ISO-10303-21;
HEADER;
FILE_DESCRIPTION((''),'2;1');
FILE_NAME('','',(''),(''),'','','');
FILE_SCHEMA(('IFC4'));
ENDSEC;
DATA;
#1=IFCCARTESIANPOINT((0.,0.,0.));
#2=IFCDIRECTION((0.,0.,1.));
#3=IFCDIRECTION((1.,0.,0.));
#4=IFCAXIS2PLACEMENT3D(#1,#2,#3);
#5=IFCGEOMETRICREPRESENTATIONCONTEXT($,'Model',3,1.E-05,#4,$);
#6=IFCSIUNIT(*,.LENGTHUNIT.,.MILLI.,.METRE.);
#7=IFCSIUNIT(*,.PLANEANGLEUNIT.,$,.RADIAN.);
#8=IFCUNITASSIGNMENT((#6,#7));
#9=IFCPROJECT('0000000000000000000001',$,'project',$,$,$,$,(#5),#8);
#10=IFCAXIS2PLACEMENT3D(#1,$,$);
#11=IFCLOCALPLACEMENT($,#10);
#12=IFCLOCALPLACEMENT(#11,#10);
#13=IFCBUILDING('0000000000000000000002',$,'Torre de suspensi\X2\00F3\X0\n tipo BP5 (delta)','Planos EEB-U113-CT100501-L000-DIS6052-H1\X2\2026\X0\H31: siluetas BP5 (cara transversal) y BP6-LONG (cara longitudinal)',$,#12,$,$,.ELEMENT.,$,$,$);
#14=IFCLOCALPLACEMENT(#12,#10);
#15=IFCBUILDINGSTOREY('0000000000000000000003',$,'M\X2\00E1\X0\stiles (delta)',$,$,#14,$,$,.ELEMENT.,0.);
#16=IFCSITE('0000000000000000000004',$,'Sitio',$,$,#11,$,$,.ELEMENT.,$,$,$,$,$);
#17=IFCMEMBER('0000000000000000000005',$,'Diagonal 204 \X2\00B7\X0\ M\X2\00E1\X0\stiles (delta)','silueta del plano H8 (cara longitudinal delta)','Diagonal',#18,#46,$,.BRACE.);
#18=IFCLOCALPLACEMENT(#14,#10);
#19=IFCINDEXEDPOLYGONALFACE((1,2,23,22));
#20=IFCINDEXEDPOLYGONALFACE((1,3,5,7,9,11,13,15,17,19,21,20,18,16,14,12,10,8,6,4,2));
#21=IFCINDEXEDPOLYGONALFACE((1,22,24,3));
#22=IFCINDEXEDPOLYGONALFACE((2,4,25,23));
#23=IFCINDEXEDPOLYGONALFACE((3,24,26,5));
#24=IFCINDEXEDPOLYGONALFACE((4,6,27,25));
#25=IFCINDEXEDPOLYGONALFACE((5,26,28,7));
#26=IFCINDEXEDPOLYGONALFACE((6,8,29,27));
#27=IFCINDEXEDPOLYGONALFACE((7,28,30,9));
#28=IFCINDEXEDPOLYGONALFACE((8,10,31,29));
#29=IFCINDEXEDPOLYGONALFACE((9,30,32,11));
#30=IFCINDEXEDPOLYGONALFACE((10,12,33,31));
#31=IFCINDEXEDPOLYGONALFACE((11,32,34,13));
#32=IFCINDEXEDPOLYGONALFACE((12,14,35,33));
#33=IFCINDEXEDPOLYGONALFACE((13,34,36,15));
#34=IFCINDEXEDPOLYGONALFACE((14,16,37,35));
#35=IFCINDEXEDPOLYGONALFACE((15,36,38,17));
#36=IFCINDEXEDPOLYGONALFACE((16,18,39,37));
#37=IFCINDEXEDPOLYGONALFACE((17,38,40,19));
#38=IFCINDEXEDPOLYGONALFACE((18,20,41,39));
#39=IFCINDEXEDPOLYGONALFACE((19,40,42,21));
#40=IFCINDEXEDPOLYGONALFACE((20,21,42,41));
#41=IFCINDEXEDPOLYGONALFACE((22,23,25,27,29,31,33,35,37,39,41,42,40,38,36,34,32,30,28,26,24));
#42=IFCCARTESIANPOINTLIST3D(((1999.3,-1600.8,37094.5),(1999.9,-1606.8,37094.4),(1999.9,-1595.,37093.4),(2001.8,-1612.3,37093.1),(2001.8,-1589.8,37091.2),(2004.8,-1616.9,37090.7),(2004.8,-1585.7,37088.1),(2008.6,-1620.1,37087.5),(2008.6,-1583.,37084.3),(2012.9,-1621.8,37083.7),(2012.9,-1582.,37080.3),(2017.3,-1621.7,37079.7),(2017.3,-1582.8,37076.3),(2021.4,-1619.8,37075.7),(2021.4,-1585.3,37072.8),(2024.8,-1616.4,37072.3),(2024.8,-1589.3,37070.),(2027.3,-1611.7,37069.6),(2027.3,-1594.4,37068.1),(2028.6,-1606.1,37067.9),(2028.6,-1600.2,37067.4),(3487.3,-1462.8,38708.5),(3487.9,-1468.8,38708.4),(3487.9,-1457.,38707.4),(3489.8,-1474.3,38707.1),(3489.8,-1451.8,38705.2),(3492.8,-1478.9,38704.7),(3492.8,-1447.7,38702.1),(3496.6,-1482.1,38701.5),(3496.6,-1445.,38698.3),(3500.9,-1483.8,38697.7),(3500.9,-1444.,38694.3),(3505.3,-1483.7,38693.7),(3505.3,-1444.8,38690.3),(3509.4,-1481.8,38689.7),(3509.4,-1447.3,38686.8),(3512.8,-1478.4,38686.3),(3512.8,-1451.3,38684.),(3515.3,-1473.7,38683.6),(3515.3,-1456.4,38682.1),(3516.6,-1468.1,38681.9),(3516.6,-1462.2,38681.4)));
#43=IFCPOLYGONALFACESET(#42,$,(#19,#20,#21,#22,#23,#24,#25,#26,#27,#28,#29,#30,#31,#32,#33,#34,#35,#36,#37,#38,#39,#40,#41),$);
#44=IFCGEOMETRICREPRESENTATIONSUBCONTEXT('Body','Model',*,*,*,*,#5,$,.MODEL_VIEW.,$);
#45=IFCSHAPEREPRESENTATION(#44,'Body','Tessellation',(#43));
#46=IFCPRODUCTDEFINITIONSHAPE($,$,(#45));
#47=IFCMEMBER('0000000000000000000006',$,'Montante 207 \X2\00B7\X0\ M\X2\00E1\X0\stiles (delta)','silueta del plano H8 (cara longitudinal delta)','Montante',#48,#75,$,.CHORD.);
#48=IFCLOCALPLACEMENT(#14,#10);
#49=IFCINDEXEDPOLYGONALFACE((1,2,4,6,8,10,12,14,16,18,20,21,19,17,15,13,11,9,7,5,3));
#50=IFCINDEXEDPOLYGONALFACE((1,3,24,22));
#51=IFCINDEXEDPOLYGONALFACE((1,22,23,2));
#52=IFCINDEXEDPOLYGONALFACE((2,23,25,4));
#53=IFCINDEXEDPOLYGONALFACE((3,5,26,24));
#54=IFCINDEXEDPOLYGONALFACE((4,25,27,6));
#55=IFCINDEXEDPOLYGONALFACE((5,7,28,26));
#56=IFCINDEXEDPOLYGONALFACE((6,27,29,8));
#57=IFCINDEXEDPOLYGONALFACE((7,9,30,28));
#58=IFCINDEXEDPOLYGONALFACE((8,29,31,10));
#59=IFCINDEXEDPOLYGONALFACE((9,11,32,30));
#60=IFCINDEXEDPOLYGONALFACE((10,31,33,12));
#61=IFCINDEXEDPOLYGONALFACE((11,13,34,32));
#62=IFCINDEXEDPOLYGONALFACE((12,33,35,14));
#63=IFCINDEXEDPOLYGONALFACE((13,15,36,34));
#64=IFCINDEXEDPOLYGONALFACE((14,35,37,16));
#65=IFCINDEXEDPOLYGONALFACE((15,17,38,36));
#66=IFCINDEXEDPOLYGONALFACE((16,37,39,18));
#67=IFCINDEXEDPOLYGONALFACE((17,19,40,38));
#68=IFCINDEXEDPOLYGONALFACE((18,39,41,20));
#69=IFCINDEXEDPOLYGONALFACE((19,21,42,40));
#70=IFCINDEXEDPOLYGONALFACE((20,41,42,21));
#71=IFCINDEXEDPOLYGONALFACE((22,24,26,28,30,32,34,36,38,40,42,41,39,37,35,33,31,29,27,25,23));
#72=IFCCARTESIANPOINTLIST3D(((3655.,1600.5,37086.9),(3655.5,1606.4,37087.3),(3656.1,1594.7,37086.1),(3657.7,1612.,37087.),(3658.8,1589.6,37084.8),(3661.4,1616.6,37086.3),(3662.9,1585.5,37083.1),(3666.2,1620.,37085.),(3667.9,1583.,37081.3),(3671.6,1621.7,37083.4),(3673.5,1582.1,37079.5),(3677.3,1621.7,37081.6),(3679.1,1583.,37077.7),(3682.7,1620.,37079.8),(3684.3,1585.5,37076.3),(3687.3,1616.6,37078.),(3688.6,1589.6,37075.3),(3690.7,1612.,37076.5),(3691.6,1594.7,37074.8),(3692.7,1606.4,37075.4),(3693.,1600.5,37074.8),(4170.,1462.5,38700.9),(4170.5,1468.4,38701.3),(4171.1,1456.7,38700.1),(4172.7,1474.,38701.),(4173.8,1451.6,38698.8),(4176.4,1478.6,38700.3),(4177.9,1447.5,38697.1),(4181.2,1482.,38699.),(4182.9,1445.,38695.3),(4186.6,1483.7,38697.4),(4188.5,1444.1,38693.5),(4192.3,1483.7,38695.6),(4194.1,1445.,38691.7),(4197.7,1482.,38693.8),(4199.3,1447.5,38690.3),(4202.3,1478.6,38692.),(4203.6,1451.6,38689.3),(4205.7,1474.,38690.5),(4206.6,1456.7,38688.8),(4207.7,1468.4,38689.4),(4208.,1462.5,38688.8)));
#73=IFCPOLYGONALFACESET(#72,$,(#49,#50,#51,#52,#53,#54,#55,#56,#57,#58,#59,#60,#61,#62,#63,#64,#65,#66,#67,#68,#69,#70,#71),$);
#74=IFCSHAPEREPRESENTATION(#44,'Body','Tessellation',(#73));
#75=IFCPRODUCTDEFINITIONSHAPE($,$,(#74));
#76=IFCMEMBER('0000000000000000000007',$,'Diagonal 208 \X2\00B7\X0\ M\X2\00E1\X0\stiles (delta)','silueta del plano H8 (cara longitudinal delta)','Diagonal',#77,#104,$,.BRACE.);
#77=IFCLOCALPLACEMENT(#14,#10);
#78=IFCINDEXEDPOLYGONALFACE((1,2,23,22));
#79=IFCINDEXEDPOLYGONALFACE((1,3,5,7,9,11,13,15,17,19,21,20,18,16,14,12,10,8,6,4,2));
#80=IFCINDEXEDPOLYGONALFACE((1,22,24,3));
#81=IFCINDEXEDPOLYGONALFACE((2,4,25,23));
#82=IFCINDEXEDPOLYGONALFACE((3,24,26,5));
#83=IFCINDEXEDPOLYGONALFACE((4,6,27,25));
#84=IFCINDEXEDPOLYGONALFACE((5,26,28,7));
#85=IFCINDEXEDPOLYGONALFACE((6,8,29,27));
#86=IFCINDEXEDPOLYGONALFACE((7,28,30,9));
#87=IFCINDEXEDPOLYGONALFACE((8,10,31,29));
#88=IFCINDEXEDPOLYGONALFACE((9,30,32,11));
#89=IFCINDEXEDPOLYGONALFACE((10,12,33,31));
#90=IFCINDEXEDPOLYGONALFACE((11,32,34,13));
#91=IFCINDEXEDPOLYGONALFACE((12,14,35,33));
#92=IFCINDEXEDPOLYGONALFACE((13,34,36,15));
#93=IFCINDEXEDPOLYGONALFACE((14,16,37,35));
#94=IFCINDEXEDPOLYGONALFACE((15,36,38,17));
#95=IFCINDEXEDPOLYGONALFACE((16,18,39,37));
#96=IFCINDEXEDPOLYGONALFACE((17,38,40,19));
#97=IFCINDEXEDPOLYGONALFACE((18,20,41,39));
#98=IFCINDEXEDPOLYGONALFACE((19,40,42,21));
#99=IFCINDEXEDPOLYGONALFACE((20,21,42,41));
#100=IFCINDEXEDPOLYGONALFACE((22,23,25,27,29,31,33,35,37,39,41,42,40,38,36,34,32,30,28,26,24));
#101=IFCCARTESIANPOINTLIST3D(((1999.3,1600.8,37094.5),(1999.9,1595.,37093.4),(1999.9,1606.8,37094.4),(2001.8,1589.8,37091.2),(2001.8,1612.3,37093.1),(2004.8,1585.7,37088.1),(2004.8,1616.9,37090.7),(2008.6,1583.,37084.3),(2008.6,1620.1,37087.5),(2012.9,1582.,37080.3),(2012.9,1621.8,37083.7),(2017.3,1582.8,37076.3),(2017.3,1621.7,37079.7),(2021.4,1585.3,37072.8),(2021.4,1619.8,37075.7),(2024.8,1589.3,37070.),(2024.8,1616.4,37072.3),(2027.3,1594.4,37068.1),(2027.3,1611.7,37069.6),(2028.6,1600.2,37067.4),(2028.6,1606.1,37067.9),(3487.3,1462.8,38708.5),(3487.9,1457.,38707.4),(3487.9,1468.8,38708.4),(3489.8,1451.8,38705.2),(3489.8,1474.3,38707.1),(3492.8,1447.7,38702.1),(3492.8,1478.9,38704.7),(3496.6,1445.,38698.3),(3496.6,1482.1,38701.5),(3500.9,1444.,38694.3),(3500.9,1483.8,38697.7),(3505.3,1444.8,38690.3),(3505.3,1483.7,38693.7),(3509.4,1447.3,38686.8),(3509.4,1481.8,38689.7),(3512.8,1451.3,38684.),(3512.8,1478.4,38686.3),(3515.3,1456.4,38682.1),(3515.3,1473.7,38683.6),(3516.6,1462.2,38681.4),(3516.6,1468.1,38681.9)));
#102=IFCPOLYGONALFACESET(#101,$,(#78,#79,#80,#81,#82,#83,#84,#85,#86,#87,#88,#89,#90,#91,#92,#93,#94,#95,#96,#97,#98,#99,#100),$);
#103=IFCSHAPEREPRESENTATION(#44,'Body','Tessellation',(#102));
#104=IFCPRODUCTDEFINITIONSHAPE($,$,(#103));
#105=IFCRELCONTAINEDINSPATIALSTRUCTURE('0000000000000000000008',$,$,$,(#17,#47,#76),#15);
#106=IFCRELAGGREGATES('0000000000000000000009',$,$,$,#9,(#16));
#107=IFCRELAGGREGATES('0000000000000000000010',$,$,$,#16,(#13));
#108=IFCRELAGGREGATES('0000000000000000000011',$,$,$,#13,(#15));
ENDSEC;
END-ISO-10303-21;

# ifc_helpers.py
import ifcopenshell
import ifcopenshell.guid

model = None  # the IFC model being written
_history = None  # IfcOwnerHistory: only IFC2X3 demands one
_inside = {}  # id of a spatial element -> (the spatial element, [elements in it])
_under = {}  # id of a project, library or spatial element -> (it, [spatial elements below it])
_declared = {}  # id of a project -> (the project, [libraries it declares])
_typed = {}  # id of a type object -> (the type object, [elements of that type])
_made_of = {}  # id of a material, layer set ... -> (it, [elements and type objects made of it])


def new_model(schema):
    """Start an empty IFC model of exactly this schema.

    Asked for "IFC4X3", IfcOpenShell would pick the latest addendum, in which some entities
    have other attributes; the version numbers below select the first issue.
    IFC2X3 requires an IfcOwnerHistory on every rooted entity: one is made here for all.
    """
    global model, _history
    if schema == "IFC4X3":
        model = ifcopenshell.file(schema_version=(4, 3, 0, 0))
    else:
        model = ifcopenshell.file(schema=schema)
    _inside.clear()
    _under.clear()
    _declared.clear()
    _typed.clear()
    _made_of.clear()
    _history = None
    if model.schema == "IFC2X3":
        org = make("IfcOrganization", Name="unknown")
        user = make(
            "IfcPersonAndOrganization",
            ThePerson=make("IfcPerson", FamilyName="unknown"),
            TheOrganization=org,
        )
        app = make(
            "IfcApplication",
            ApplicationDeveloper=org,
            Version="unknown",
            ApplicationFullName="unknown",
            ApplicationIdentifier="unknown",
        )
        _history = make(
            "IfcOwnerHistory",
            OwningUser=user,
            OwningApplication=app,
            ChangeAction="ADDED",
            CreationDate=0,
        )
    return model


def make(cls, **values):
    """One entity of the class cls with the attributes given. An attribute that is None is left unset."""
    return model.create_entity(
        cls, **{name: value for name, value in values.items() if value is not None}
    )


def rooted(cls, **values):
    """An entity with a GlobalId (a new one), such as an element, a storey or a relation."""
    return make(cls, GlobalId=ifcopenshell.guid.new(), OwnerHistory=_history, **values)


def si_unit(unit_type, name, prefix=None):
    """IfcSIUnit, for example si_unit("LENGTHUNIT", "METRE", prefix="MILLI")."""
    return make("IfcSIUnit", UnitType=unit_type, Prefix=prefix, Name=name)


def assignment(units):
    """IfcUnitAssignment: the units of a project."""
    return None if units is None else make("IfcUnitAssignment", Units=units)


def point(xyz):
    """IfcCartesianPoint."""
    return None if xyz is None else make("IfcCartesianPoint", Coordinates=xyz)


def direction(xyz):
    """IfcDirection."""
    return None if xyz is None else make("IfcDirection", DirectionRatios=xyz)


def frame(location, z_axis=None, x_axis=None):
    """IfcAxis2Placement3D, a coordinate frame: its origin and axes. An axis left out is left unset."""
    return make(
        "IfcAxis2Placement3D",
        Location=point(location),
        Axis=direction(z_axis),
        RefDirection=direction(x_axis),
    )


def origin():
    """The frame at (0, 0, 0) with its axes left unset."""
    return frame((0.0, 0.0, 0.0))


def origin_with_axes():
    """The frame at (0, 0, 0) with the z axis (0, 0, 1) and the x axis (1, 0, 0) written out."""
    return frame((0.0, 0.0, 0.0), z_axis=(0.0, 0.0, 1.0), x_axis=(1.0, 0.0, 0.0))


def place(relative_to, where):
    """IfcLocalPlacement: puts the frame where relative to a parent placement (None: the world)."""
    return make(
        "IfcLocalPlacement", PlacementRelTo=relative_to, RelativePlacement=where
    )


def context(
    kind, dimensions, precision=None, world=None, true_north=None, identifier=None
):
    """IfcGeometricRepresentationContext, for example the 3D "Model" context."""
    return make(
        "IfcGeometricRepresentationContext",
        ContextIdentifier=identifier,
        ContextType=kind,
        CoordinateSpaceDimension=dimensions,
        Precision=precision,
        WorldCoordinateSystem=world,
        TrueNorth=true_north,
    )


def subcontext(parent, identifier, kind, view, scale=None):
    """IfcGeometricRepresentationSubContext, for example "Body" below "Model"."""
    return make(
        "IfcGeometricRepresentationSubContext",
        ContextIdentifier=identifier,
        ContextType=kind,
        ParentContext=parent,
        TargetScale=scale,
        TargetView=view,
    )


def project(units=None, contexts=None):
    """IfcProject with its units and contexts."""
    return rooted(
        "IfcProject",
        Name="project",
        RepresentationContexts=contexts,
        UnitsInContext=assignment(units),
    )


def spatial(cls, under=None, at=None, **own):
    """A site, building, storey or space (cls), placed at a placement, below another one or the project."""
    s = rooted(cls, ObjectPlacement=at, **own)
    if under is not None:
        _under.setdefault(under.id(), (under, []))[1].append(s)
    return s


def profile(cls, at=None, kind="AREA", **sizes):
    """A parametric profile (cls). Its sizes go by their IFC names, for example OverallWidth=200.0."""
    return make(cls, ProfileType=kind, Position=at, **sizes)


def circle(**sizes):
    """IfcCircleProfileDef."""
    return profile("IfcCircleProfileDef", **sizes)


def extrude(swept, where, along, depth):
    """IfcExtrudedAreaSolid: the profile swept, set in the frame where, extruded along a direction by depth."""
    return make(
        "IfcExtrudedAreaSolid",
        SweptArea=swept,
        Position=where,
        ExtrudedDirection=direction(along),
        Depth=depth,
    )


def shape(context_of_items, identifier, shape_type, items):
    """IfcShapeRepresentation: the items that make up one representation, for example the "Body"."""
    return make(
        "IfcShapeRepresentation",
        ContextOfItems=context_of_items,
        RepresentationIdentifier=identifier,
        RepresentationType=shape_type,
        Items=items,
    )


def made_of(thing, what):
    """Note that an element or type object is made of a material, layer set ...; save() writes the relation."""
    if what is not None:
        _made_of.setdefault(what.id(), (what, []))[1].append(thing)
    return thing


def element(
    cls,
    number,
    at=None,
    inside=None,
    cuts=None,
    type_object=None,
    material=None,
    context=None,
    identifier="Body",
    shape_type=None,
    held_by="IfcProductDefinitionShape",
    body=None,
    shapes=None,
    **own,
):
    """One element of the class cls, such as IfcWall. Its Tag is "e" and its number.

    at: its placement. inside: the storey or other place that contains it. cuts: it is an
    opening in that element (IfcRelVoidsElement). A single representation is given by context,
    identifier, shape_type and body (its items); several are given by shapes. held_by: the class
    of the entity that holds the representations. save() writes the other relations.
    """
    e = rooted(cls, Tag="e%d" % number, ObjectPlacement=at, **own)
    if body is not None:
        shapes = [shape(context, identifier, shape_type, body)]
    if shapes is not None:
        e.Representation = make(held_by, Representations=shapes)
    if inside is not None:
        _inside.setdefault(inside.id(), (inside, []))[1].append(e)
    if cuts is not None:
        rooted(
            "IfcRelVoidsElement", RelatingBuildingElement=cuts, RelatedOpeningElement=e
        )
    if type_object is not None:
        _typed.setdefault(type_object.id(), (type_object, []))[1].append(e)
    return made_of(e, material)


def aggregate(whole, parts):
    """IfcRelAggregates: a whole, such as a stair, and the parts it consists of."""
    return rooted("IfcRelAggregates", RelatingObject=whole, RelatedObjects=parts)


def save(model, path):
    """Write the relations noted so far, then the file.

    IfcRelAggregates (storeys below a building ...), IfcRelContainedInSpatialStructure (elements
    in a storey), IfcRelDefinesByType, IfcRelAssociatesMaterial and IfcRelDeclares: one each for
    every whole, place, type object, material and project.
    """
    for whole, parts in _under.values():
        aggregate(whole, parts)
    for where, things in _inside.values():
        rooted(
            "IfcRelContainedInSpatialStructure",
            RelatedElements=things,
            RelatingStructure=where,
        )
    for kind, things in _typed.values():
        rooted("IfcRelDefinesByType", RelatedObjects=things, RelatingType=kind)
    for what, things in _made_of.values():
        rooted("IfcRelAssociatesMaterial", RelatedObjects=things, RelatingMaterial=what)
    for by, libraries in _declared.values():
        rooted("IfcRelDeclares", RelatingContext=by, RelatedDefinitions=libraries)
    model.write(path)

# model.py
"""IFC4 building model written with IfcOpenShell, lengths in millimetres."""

from ifc_helpers import new_model, si_unit, frame, origin, origin_with_axes, place, context, subcontext, project, spatial, circle, extrude, element, save


model = new_model("IFC4")

# Units and contexts
model_context = context("Model", 3, precision=1e-05, world=origin_with_axes())
body_context = subcontext(model_context, "Body", "Model", "MODEL_VIEW")
ifc_project = project(units=[si_unit("LENGTHUNIT", "METRE", prefix="MILLI"), si_unit("PLANEANGLEUNIT", "RADIAN")], contexts=[model_context])

# Site, building, storey
site_placement = place(None, origin())
site = spatial("IfcSite", under=ifc_project, at=site_placement, Name="Sitio", CompositionType="ELEMENT")
building_placement = place(site_placement, origin())
building = spatial("IfcBuilding", under=site, at=building_placement, Name="Torre de suspensión tipo BP5 (delta)", Description="Planos EEB-U113-CT100501-L000-DIS6052-H1…H31: siluetas BP5 (cara transversal) y BP6-LONG (cara longitudinal)", CompositionType="ELEMENT")
storey_placement = place(building_placement, origin())
storey = spatial("IfcBuildingStorey", under=building, at=storey_placement, Name="Mástiles (delta)", CompositionType="ELEMENT", Elevation=0.0)

# Members
member_1_placement = place(storey_placement, frame((3502.0, -1464.0, 38695.0), z_axis=(-0.676491, -0.062739, -0.733774), x_axis=(-0.736451, 0.057631, 0.674031)))
element("IfcMember", 1, at=member_1_placement, inside=storey, Name="Diagonal 204 · Mástiles (delta)", Description="silueta del plano H8 (cara longitudinal delta)", ObjectType="Diagonal", PredefinedType="BRACE", context=body_context, shape_type="SweptSolid", body=[
    extrude(circle(Radius=20.0), None, (0.0, 0.0, 1.0), 2199.6),
])
member_2_placement = place(storey_placement, frame((4189.0, 1464.0, 38695.0), z_axis=(-0.30298, 0.081187, -0.949533), x_axis=(-0.024679, -0.996699, -0.077345)))
element("IfcMember", 2, at=member_2_placement, inside=storey, Name="Montante 207 · Mástiles (delta)", Description="silueta del plano H8 (cara longitudinal delta)", ObjectType="Montante", PredefinedType="CHORD", context=body_context, shape_type="SweptSolid", body=[
    extrude(circle(Radius=20.0), None, (0.0, 0.0, 1.0), 1699.8),
])
member_3_placement = place(storey_placement, frame((3502.0, 1464.0, 38695.0), z_axis=(-0.676491, 0.062739, -0.733774), x_axis=(-0.736451, -0.057631, 0.674031)))
element("IfcMember", 3, at=member_3_placement, inside=storey, Name="Diagonal 208 · Mástiles (delta)", Description="silueta del plano H8 (cara longitudinal delta)", ObjectType="Diagonal", PredefinedType="BRACE", context=body_context, shape_type="SweptSolid", body=[
    extrude(circle(Radius=20.0), None, (0.0, 0.0, 1.0), 2199.6),
])

save(model, "model.ifc")
